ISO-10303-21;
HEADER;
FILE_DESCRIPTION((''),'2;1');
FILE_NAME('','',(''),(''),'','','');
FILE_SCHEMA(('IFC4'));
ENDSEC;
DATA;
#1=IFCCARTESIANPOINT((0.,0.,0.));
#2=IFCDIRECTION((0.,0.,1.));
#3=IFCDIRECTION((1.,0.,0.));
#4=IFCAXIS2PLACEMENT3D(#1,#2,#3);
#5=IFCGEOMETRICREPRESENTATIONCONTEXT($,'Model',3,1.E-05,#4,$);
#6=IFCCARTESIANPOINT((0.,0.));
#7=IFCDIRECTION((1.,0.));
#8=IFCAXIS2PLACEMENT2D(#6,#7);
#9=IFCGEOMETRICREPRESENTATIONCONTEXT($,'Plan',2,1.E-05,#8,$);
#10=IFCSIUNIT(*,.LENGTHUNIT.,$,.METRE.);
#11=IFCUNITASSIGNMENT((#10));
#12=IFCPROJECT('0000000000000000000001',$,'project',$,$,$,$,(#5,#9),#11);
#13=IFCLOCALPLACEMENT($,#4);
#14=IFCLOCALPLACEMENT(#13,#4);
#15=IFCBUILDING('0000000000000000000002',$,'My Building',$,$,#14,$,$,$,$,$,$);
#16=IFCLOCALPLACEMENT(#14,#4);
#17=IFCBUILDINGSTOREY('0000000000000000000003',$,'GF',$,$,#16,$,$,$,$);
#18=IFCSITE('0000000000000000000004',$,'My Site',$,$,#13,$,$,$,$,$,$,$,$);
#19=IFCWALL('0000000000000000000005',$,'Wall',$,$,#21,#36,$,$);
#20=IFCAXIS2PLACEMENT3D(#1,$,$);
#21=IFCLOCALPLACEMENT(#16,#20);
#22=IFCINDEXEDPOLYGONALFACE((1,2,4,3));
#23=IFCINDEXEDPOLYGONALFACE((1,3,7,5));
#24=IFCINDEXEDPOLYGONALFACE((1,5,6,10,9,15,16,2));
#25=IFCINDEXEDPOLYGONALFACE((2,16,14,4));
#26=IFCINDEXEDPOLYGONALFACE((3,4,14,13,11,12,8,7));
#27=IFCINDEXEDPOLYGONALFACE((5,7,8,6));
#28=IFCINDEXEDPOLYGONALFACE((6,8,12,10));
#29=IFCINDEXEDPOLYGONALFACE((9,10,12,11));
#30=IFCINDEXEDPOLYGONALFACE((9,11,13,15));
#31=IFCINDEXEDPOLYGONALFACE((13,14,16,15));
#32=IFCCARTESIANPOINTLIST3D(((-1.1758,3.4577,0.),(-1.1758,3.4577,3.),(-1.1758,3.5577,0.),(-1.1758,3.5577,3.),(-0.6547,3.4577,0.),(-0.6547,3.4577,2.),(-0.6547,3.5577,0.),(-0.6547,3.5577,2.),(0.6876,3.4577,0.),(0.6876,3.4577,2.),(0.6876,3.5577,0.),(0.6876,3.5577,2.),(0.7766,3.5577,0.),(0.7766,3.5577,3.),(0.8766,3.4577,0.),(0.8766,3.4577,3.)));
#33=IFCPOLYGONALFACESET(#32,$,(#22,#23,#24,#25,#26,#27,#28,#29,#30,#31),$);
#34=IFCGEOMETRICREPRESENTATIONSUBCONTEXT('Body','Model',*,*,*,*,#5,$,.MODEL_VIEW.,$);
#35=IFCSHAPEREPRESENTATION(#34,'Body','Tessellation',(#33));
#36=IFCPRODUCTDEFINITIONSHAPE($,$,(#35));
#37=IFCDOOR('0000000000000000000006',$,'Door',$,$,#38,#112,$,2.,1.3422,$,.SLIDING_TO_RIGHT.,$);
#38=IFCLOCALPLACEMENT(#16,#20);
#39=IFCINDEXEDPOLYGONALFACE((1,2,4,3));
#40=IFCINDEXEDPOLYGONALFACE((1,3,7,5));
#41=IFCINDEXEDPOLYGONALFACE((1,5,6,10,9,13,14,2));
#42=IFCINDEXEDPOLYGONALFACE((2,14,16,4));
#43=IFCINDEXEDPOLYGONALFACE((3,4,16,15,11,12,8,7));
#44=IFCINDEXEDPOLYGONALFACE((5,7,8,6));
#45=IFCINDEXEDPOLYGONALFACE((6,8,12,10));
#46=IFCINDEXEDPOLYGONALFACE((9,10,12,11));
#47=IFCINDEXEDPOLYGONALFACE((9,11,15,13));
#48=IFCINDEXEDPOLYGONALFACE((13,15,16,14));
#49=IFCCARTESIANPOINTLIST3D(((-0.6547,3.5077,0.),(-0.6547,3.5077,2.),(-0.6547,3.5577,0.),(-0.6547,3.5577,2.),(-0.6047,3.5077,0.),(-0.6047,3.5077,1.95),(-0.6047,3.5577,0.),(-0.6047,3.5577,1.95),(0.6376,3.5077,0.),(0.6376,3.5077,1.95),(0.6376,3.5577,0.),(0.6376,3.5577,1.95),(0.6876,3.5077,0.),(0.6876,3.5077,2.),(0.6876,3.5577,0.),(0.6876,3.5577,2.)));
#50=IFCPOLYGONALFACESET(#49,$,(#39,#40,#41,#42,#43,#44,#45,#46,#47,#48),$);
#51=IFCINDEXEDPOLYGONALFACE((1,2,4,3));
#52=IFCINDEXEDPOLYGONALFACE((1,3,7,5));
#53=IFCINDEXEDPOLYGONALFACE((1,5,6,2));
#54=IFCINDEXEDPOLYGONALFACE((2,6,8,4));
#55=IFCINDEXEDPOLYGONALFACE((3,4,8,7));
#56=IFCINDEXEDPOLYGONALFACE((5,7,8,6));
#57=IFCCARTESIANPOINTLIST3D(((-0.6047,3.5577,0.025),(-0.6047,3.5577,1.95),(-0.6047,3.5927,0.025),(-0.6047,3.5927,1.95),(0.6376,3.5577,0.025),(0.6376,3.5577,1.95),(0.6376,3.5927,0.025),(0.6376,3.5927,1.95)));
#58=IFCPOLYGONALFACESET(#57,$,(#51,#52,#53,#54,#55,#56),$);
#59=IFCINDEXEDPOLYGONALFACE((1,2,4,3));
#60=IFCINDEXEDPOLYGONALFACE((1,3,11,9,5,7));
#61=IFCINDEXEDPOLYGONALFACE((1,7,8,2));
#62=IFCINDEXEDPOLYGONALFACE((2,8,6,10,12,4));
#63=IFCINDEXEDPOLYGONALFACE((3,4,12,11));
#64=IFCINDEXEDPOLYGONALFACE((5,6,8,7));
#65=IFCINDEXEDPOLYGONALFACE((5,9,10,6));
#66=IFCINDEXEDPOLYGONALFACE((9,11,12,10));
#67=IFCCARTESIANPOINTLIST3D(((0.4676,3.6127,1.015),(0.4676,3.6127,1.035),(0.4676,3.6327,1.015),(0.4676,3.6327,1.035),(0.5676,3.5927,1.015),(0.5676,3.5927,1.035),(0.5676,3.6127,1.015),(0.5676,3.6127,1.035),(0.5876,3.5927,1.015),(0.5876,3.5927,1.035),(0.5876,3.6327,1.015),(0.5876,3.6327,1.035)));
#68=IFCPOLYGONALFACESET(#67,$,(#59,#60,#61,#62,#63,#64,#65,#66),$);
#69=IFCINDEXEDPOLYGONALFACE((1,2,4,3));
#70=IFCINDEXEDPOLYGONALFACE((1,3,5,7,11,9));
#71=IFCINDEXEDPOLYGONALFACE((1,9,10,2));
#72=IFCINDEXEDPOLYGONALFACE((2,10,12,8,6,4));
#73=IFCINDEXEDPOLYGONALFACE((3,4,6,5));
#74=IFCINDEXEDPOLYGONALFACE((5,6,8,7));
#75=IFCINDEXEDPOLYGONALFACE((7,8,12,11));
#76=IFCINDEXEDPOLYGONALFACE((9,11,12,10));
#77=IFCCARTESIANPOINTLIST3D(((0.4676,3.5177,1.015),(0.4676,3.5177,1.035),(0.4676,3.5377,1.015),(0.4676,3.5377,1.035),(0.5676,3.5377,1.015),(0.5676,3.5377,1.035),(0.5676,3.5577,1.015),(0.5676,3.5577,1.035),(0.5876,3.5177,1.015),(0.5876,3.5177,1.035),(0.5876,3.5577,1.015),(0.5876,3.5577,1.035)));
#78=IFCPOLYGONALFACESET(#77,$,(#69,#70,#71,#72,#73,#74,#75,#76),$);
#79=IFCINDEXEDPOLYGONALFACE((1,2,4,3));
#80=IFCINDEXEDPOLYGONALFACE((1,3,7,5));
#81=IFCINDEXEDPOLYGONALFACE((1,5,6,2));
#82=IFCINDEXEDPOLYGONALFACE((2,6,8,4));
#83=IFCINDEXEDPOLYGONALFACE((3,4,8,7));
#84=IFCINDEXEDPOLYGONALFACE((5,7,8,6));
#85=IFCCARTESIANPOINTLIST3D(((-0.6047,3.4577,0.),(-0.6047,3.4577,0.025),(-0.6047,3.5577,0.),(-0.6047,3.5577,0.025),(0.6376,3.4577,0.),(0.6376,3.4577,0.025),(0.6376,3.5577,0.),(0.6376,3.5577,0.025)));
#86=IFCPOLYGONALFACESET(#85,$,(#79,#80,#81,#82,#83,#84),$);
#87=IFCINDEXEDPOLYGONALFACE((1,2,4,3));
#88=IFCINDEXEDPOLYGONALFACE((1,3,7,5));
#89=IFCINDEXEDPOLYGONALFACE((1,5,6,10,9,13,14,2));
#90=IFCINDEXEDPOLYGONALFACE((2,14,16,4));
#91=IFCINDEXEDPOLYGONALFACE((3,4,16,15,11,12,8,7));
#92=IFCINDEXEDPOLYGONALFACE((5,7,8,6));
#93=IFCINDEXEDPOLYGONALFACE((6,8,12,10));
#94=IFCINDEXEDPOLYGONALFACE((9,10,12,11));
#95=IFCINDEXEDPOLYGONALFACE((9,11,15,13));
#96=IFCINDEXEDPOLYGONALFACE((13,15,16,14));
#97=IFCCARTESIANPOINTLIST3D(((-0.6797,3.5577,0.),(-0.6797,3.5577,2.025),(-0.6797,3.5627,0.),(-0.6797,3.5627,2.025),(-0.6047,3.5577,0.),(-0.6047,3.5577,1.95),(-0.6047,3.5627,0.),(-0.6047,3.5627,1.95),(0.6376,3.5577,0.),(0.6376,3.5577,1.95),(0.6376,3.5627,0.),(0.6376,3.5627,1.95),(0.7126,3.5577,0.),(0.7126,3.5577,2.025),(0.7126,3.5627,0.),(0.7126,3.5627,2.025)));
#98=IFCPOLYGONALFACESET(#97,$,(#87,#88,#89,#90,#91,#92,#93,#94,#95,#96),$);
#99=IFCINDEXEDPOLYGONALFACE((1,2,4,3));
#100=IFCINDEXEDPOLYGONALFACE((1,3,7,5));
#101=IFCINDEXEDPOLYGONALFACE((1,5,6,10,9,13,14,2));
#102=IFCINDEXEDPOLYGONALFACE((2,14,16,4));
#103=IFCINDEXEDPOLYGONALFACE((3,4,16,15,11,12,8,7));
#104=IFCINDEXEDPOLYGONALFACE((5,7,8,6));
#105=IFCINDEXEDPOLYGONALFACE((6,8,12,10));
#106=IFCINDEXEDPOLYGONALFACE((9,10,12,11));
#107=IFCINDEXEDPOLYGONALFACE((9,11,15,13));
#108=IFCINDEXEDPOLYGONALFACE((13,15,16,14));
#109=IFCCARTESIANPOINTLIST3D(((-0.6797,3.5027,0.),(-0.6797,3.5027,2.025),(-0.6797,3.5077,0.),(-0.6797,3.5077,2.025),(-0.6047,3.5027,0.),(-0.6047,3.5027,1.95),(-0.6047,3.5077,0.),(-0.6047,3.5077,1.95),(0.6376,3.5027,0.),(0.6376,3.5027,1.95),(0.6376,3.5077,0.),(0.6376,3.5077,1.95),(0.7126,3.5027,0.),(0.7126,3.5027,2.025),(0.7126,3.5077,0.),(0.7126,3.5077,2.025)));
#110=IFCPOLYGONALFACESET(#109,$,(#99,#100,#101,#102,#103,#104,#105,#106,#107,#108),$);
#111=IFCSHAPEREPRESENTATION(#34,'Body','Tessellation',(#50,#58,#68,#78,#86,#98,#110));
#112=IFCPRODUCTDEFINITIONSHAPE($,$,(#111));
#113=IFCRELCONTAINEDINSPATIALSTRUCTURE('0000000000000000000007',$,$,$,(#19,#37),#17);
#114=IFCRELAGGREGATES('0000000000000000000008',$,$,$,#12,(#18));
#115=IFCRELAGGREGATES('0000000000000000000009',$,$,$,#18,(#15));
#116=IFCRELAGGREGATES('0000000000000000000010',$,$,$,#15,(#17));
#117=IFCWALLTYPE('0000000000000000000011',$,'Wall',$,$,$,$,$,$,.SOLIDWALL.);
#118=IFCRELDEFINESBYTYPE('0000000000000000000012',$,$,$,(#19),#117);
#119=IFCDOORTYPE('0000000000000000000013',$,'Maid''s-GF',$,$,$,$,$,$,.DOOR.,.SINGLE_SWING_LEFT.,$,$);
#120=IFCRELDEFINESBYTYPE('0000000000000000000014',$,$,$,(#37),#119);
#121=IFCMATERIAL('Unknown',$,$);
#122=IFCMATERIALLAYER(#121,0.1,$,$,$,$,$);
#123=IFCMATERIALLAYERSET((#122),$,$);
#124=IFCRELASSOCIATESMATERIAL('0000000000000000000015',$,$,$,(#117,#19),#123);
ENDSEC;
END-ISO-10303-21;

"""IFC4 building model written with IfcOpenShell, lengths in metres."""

from ifc_helpers import new_model, entity, si_unit, frame, origin_with_axes, origin_2d_with_axis, place, context, subcontext, project, spatial, line, indexed_curve, outline, extrude, shape, source, transform, mapped, material, layer, layer_set, layer_usage, type_object, type_shapes, element, fill, save


model = new_model("IFC4")

# Units and contexts
model_context = context("Model", 3, precision=1e-05, world=origin_with_axes())
plan_context = context("Plan", 2, precision=1e-05, world=origin_2d_with_axis())
body_context_1 = subcontext(model_context, "Body", "Model", "MODEL_VIEW")
body_context_2 = subcontext(plan_context, "Body", "Plan", "PLAN_VIEW")
ifc_project = project(units=[si_unit("LENGTHUNIT", "METRE")], contexts=[model_context, plan_context])

# Site, building, storey
site_placement = place(None, origin_with_axes())
site = spatial("IfcSite", under=ifc_project, at=site_placement, Name="My Site")
building_placement = place(site_placement, origin_with_axes())
building = spatial("IfcBuilding", under=site, at=building_placement, Name="My Building")
storey_placement = place(building_placement, origin_with_axes())
storey = spatial("IfcBuildingStorey", under=building, at=storey_placement, Name="GF")

# Shared definitions
ifc_material_1 = material(Name="Unknown")

# Shared definitions
ifc_layer_1 = layer(ifc_material_1, 0.1)
ifc_layer_set_1 = layer_set([ifc_layer_1])
wall_type = type_object("IfcWallType", Name="Wall", PredefinedType="SOLIDWALL", material=ifc_layer_set_1)

# Wall, opening, door
ifc_layer_usage_1 = layer_usage(ifc_layer_set_1, "AXIS2", "POSITIVE", 0.0)
wall_1_placement = place(storey_placement, frame((0.7766, 3.5577, 0.0), z_axis=(0.0, 0.0, 1.0), x_axis=(-1.0, 0.0, 0.0)))
wall_1 = element("IfcWall", 1, at=wall_1_placement, inside=storey, type_object=wall_type, material=ifc_layer_usage_1, Name="Wall", context=body_context_1, shape_type="SweptSolid", body=[
    extrude(outline(indexed_curve([(0.0, 0.0), (-0.1, 0.1), (1.9525, 0.1), (1.9525, 0.0)], segments=[line(1, 2, 3, 4, 1)])), origin_with_axes(), (0.0, 0.0, 1.0), 3.0),
])
shared_shape_1 = source(origin_with_axes(), body_context_1, "Body", "SweptSolid", [
    extrude(outline(indexed_curve([(0.0, 0.0), (1.3422, 0.0), (1.3422, 2.0), (0.0, 2.0)], segments=[line(1, 2, 3, 4, 1)])), frame((0.0, -0.6, 0.0), z_axis=(0.0, -1.0, 0.0), x_axis=(1.0, 0.0, 0.0)), (0.0, 0.0, -1.0), 1.2),
])
opening_1_placement = place(wall_1_placement, frame((0.089, 0.0, 0.0), z_axis=(0.0, 0.0, 1.0), x_axis=(1.0, -0.000001, 0.0)))
opening_1 = element("IfcOpeningElement", 2, at=opening_1_placement, cuts=wall_1, PredefinedType="OPENING", context=body_context_1, shape_type="MappedRepresentation", body=[
    mapped(shared_shape_1, transform((0.0, 0.0, 0.0), x_axis=(1.0, 0.0, 0.0), y_axis=(0.0, 1.0, 0.0), z_axis=(0.0, 0.0, 1.0), scale=1.0)),
])
door_type_1 = type_object("IfcDoorType", Name="Maid's-GF", OperationType="SINGLE_SWING_LEFT", PredefinedType="DOOR")
shared_shape_2 = source(origin_with_axes(), body_context_1, "Body", "SweptSolid", [
    extrude(outline(indexed_curve([(0.0, 0.0), (0.0, 2.0), (1.3422, 2.0), (1.3422, 0.0), (1.2922, 0.0), (1.2922, 1.95), (0.05, 1.95), (0.05, 0.0)], segments=[line(1, 2, 3, 4, 5, 6, 7, 8, 1)])), frame((0.0, 0.0, 0.0), z_axis=(0.0, -1.0, 0.0), x_axis=(1.0, 0.0, 0.0)), (0.0, 0.0, -1.0), 0.05),
    extrude(outline(indexed_curve([(0.0, 0.0), (1.2422, 0.0), (1.2422, 0.035), (0.0, 0.035)], segments=[line(1, 2, 3, 4, 1)])), frame((0.05, -0.035, 0.025), z_axis=(0.0, 0.0, 1.0), x_axis=(1.0, 0.0, 0.0)), (0.0, 0.0, 1.0), 1.925),
    extrude(outline(indexed_curve([(0.0, 0.0), (0.0, -0.04), (0.12, -0.04), (0.12, -0.02), (0.02, -0.02), (0.02, 0.0)], segments=[line(1, 2, 3, 4, 5, 6, 1)])), frame((0.1, -0.035, 1.015), z_axis=(0.0, 0.0, 1.0), x_axis=(1.0, 0.0, 0.0)), (0.0, 0.0, 1.0), 0.02),
    extrude(outline(indexed_curve([(0.0, 0.0), (0.0, 0.04), (0.12, 0.04), (0.12, 0.02), (0.02, 0.02), (0.02, 0.0)], segments=[line(1, 2, 3, 4, 5, 6, 1)])), frame((0.1, 0.0, 1.015), z_axis=(0.0, 0.0, 1.0), x_axis=(1.0, 0.0, 0.0)), (0.0, 0.0, 1.0), 0.02),
    extrude(outline(indexed_curve([(0.0, 0.0), (1.2422, 0.0), (1.2422, 0.1), (0.0, 0.1)], segments=[line(1, 2, 3, 4, 1)])), frame((0.05, 0.0, 0.0), z_axis=(0.0, 0.0, 1.0), x_axis=(1.0, 0.0, 0.0)), (0.0, 0.0, 1.0), 0.025),
    extrude(outline(indexed_curve([(0.0, 0.0), (0.0, 2.025), (1.3922, 2.025), (1.3922, 0.0), (1.3172, 0.0), (1.3172, 1.95), (0.075, 1.95), (0.075, 0.0)], segments=[line(1, 2, 3, 4, 5, 6, 7, 8, 1)])), frame((-0.025, -0.005, 0.0), z_axis=(0.0, -1.0, 0.0), x_axis=(1.0, 0.0, 0.0)), (0.0, 0.0, -1.0), 0.005),
    extrude(outline(indexed_curve([(0.0, 0.0), (0.0, 2.025), (1.3922, 2.025), (1.3922, 0.0), (1.3172, 0.0), (1.3172, 1.95), (0.075, 1.95), (0.075, 0.0)], segments=[line(1, 2, 3, 4, 5, 6, 7, 8, 1)])), frame((-0.025, 0.05, 0.0), z_axis=(0.0, -1.0, 0.0), x_axis=(1.0, 0.0, 0.0)), (0.0, 0.0, -1.0), 0.005),
])
shared_shape_3 = source(origin_with_axes(), body_context_2, "Body", "Curve2D", [
    entity("IfcIndexedPolyCurve", entity("IfcCartesianPointList2D", [[0.0, 0.0], [0.05, 0.0], [0.05, 0.05], [0.0, 0.05]]), [entity("IfcLineIndex", [1, 2, 3, 4, 1])]),
    entity("IfcIndexedPolyCurve", entity("IfcCartesianPointList2D", [[1.3422, 0.0], [1.2922, 0.0], [1.2922, 0.05], [1.3422, 0.05]]), [entity("IfcLineIndex", [1, 2, 3, 4, 1])]),
    entity("IfcIndexedPolyCurve", entity("IfcCartesianPointList2D", [[1.9134, -0.035], [0.6711, -0.035], [0.6711, 0.0], [1.9134, 0.0]]), [entity("IfcLineIndex", [1, 2, 3, 4, 1])]),
])
type_shapes(door_type_1, [shared_shape_2, shared_shape_3])
door_1_placement = place(opening_1_placement, frame((0.0, 0.0, 0.0), z_axis=(0.0, 0.0, 1.0), x_axis=(1.0, 0.0, 0.0)))
door_1 = element("IfcDoor", 3, at=door_1_placement, inside=storey, type_object=door_type_1, Name="Door", OperationType="SLIDING_TO_RIGHT", OverallHeight=2.0, OverallWidth=1.3422, shapes=[
    shape(body_context_1, "Body", "MappedRepresentation", [mapped(shared_shape_2, transform((0.0, 0.0, 0.0), x_axis=(1.0, 0.0, 0.0), y_axis=(0.0, 1.0, 0.0), z_axis=(0.0, 0.0, 1.0), scale=1.0))]),
    shape(body_context_2, "Body", "MappedRepresentation", [mapped(shared_shape_3, transform((0.0, 0.0, 0.0), x_axis=(1.0, 0.0, 0.0), y_axis=(0.0, 1.0, 0.0), z_axis=(0.0, 0.0, 1.0), scale=1.0))]),
])
fill(opening_1, door_1)

save(model, "model.ifc")
